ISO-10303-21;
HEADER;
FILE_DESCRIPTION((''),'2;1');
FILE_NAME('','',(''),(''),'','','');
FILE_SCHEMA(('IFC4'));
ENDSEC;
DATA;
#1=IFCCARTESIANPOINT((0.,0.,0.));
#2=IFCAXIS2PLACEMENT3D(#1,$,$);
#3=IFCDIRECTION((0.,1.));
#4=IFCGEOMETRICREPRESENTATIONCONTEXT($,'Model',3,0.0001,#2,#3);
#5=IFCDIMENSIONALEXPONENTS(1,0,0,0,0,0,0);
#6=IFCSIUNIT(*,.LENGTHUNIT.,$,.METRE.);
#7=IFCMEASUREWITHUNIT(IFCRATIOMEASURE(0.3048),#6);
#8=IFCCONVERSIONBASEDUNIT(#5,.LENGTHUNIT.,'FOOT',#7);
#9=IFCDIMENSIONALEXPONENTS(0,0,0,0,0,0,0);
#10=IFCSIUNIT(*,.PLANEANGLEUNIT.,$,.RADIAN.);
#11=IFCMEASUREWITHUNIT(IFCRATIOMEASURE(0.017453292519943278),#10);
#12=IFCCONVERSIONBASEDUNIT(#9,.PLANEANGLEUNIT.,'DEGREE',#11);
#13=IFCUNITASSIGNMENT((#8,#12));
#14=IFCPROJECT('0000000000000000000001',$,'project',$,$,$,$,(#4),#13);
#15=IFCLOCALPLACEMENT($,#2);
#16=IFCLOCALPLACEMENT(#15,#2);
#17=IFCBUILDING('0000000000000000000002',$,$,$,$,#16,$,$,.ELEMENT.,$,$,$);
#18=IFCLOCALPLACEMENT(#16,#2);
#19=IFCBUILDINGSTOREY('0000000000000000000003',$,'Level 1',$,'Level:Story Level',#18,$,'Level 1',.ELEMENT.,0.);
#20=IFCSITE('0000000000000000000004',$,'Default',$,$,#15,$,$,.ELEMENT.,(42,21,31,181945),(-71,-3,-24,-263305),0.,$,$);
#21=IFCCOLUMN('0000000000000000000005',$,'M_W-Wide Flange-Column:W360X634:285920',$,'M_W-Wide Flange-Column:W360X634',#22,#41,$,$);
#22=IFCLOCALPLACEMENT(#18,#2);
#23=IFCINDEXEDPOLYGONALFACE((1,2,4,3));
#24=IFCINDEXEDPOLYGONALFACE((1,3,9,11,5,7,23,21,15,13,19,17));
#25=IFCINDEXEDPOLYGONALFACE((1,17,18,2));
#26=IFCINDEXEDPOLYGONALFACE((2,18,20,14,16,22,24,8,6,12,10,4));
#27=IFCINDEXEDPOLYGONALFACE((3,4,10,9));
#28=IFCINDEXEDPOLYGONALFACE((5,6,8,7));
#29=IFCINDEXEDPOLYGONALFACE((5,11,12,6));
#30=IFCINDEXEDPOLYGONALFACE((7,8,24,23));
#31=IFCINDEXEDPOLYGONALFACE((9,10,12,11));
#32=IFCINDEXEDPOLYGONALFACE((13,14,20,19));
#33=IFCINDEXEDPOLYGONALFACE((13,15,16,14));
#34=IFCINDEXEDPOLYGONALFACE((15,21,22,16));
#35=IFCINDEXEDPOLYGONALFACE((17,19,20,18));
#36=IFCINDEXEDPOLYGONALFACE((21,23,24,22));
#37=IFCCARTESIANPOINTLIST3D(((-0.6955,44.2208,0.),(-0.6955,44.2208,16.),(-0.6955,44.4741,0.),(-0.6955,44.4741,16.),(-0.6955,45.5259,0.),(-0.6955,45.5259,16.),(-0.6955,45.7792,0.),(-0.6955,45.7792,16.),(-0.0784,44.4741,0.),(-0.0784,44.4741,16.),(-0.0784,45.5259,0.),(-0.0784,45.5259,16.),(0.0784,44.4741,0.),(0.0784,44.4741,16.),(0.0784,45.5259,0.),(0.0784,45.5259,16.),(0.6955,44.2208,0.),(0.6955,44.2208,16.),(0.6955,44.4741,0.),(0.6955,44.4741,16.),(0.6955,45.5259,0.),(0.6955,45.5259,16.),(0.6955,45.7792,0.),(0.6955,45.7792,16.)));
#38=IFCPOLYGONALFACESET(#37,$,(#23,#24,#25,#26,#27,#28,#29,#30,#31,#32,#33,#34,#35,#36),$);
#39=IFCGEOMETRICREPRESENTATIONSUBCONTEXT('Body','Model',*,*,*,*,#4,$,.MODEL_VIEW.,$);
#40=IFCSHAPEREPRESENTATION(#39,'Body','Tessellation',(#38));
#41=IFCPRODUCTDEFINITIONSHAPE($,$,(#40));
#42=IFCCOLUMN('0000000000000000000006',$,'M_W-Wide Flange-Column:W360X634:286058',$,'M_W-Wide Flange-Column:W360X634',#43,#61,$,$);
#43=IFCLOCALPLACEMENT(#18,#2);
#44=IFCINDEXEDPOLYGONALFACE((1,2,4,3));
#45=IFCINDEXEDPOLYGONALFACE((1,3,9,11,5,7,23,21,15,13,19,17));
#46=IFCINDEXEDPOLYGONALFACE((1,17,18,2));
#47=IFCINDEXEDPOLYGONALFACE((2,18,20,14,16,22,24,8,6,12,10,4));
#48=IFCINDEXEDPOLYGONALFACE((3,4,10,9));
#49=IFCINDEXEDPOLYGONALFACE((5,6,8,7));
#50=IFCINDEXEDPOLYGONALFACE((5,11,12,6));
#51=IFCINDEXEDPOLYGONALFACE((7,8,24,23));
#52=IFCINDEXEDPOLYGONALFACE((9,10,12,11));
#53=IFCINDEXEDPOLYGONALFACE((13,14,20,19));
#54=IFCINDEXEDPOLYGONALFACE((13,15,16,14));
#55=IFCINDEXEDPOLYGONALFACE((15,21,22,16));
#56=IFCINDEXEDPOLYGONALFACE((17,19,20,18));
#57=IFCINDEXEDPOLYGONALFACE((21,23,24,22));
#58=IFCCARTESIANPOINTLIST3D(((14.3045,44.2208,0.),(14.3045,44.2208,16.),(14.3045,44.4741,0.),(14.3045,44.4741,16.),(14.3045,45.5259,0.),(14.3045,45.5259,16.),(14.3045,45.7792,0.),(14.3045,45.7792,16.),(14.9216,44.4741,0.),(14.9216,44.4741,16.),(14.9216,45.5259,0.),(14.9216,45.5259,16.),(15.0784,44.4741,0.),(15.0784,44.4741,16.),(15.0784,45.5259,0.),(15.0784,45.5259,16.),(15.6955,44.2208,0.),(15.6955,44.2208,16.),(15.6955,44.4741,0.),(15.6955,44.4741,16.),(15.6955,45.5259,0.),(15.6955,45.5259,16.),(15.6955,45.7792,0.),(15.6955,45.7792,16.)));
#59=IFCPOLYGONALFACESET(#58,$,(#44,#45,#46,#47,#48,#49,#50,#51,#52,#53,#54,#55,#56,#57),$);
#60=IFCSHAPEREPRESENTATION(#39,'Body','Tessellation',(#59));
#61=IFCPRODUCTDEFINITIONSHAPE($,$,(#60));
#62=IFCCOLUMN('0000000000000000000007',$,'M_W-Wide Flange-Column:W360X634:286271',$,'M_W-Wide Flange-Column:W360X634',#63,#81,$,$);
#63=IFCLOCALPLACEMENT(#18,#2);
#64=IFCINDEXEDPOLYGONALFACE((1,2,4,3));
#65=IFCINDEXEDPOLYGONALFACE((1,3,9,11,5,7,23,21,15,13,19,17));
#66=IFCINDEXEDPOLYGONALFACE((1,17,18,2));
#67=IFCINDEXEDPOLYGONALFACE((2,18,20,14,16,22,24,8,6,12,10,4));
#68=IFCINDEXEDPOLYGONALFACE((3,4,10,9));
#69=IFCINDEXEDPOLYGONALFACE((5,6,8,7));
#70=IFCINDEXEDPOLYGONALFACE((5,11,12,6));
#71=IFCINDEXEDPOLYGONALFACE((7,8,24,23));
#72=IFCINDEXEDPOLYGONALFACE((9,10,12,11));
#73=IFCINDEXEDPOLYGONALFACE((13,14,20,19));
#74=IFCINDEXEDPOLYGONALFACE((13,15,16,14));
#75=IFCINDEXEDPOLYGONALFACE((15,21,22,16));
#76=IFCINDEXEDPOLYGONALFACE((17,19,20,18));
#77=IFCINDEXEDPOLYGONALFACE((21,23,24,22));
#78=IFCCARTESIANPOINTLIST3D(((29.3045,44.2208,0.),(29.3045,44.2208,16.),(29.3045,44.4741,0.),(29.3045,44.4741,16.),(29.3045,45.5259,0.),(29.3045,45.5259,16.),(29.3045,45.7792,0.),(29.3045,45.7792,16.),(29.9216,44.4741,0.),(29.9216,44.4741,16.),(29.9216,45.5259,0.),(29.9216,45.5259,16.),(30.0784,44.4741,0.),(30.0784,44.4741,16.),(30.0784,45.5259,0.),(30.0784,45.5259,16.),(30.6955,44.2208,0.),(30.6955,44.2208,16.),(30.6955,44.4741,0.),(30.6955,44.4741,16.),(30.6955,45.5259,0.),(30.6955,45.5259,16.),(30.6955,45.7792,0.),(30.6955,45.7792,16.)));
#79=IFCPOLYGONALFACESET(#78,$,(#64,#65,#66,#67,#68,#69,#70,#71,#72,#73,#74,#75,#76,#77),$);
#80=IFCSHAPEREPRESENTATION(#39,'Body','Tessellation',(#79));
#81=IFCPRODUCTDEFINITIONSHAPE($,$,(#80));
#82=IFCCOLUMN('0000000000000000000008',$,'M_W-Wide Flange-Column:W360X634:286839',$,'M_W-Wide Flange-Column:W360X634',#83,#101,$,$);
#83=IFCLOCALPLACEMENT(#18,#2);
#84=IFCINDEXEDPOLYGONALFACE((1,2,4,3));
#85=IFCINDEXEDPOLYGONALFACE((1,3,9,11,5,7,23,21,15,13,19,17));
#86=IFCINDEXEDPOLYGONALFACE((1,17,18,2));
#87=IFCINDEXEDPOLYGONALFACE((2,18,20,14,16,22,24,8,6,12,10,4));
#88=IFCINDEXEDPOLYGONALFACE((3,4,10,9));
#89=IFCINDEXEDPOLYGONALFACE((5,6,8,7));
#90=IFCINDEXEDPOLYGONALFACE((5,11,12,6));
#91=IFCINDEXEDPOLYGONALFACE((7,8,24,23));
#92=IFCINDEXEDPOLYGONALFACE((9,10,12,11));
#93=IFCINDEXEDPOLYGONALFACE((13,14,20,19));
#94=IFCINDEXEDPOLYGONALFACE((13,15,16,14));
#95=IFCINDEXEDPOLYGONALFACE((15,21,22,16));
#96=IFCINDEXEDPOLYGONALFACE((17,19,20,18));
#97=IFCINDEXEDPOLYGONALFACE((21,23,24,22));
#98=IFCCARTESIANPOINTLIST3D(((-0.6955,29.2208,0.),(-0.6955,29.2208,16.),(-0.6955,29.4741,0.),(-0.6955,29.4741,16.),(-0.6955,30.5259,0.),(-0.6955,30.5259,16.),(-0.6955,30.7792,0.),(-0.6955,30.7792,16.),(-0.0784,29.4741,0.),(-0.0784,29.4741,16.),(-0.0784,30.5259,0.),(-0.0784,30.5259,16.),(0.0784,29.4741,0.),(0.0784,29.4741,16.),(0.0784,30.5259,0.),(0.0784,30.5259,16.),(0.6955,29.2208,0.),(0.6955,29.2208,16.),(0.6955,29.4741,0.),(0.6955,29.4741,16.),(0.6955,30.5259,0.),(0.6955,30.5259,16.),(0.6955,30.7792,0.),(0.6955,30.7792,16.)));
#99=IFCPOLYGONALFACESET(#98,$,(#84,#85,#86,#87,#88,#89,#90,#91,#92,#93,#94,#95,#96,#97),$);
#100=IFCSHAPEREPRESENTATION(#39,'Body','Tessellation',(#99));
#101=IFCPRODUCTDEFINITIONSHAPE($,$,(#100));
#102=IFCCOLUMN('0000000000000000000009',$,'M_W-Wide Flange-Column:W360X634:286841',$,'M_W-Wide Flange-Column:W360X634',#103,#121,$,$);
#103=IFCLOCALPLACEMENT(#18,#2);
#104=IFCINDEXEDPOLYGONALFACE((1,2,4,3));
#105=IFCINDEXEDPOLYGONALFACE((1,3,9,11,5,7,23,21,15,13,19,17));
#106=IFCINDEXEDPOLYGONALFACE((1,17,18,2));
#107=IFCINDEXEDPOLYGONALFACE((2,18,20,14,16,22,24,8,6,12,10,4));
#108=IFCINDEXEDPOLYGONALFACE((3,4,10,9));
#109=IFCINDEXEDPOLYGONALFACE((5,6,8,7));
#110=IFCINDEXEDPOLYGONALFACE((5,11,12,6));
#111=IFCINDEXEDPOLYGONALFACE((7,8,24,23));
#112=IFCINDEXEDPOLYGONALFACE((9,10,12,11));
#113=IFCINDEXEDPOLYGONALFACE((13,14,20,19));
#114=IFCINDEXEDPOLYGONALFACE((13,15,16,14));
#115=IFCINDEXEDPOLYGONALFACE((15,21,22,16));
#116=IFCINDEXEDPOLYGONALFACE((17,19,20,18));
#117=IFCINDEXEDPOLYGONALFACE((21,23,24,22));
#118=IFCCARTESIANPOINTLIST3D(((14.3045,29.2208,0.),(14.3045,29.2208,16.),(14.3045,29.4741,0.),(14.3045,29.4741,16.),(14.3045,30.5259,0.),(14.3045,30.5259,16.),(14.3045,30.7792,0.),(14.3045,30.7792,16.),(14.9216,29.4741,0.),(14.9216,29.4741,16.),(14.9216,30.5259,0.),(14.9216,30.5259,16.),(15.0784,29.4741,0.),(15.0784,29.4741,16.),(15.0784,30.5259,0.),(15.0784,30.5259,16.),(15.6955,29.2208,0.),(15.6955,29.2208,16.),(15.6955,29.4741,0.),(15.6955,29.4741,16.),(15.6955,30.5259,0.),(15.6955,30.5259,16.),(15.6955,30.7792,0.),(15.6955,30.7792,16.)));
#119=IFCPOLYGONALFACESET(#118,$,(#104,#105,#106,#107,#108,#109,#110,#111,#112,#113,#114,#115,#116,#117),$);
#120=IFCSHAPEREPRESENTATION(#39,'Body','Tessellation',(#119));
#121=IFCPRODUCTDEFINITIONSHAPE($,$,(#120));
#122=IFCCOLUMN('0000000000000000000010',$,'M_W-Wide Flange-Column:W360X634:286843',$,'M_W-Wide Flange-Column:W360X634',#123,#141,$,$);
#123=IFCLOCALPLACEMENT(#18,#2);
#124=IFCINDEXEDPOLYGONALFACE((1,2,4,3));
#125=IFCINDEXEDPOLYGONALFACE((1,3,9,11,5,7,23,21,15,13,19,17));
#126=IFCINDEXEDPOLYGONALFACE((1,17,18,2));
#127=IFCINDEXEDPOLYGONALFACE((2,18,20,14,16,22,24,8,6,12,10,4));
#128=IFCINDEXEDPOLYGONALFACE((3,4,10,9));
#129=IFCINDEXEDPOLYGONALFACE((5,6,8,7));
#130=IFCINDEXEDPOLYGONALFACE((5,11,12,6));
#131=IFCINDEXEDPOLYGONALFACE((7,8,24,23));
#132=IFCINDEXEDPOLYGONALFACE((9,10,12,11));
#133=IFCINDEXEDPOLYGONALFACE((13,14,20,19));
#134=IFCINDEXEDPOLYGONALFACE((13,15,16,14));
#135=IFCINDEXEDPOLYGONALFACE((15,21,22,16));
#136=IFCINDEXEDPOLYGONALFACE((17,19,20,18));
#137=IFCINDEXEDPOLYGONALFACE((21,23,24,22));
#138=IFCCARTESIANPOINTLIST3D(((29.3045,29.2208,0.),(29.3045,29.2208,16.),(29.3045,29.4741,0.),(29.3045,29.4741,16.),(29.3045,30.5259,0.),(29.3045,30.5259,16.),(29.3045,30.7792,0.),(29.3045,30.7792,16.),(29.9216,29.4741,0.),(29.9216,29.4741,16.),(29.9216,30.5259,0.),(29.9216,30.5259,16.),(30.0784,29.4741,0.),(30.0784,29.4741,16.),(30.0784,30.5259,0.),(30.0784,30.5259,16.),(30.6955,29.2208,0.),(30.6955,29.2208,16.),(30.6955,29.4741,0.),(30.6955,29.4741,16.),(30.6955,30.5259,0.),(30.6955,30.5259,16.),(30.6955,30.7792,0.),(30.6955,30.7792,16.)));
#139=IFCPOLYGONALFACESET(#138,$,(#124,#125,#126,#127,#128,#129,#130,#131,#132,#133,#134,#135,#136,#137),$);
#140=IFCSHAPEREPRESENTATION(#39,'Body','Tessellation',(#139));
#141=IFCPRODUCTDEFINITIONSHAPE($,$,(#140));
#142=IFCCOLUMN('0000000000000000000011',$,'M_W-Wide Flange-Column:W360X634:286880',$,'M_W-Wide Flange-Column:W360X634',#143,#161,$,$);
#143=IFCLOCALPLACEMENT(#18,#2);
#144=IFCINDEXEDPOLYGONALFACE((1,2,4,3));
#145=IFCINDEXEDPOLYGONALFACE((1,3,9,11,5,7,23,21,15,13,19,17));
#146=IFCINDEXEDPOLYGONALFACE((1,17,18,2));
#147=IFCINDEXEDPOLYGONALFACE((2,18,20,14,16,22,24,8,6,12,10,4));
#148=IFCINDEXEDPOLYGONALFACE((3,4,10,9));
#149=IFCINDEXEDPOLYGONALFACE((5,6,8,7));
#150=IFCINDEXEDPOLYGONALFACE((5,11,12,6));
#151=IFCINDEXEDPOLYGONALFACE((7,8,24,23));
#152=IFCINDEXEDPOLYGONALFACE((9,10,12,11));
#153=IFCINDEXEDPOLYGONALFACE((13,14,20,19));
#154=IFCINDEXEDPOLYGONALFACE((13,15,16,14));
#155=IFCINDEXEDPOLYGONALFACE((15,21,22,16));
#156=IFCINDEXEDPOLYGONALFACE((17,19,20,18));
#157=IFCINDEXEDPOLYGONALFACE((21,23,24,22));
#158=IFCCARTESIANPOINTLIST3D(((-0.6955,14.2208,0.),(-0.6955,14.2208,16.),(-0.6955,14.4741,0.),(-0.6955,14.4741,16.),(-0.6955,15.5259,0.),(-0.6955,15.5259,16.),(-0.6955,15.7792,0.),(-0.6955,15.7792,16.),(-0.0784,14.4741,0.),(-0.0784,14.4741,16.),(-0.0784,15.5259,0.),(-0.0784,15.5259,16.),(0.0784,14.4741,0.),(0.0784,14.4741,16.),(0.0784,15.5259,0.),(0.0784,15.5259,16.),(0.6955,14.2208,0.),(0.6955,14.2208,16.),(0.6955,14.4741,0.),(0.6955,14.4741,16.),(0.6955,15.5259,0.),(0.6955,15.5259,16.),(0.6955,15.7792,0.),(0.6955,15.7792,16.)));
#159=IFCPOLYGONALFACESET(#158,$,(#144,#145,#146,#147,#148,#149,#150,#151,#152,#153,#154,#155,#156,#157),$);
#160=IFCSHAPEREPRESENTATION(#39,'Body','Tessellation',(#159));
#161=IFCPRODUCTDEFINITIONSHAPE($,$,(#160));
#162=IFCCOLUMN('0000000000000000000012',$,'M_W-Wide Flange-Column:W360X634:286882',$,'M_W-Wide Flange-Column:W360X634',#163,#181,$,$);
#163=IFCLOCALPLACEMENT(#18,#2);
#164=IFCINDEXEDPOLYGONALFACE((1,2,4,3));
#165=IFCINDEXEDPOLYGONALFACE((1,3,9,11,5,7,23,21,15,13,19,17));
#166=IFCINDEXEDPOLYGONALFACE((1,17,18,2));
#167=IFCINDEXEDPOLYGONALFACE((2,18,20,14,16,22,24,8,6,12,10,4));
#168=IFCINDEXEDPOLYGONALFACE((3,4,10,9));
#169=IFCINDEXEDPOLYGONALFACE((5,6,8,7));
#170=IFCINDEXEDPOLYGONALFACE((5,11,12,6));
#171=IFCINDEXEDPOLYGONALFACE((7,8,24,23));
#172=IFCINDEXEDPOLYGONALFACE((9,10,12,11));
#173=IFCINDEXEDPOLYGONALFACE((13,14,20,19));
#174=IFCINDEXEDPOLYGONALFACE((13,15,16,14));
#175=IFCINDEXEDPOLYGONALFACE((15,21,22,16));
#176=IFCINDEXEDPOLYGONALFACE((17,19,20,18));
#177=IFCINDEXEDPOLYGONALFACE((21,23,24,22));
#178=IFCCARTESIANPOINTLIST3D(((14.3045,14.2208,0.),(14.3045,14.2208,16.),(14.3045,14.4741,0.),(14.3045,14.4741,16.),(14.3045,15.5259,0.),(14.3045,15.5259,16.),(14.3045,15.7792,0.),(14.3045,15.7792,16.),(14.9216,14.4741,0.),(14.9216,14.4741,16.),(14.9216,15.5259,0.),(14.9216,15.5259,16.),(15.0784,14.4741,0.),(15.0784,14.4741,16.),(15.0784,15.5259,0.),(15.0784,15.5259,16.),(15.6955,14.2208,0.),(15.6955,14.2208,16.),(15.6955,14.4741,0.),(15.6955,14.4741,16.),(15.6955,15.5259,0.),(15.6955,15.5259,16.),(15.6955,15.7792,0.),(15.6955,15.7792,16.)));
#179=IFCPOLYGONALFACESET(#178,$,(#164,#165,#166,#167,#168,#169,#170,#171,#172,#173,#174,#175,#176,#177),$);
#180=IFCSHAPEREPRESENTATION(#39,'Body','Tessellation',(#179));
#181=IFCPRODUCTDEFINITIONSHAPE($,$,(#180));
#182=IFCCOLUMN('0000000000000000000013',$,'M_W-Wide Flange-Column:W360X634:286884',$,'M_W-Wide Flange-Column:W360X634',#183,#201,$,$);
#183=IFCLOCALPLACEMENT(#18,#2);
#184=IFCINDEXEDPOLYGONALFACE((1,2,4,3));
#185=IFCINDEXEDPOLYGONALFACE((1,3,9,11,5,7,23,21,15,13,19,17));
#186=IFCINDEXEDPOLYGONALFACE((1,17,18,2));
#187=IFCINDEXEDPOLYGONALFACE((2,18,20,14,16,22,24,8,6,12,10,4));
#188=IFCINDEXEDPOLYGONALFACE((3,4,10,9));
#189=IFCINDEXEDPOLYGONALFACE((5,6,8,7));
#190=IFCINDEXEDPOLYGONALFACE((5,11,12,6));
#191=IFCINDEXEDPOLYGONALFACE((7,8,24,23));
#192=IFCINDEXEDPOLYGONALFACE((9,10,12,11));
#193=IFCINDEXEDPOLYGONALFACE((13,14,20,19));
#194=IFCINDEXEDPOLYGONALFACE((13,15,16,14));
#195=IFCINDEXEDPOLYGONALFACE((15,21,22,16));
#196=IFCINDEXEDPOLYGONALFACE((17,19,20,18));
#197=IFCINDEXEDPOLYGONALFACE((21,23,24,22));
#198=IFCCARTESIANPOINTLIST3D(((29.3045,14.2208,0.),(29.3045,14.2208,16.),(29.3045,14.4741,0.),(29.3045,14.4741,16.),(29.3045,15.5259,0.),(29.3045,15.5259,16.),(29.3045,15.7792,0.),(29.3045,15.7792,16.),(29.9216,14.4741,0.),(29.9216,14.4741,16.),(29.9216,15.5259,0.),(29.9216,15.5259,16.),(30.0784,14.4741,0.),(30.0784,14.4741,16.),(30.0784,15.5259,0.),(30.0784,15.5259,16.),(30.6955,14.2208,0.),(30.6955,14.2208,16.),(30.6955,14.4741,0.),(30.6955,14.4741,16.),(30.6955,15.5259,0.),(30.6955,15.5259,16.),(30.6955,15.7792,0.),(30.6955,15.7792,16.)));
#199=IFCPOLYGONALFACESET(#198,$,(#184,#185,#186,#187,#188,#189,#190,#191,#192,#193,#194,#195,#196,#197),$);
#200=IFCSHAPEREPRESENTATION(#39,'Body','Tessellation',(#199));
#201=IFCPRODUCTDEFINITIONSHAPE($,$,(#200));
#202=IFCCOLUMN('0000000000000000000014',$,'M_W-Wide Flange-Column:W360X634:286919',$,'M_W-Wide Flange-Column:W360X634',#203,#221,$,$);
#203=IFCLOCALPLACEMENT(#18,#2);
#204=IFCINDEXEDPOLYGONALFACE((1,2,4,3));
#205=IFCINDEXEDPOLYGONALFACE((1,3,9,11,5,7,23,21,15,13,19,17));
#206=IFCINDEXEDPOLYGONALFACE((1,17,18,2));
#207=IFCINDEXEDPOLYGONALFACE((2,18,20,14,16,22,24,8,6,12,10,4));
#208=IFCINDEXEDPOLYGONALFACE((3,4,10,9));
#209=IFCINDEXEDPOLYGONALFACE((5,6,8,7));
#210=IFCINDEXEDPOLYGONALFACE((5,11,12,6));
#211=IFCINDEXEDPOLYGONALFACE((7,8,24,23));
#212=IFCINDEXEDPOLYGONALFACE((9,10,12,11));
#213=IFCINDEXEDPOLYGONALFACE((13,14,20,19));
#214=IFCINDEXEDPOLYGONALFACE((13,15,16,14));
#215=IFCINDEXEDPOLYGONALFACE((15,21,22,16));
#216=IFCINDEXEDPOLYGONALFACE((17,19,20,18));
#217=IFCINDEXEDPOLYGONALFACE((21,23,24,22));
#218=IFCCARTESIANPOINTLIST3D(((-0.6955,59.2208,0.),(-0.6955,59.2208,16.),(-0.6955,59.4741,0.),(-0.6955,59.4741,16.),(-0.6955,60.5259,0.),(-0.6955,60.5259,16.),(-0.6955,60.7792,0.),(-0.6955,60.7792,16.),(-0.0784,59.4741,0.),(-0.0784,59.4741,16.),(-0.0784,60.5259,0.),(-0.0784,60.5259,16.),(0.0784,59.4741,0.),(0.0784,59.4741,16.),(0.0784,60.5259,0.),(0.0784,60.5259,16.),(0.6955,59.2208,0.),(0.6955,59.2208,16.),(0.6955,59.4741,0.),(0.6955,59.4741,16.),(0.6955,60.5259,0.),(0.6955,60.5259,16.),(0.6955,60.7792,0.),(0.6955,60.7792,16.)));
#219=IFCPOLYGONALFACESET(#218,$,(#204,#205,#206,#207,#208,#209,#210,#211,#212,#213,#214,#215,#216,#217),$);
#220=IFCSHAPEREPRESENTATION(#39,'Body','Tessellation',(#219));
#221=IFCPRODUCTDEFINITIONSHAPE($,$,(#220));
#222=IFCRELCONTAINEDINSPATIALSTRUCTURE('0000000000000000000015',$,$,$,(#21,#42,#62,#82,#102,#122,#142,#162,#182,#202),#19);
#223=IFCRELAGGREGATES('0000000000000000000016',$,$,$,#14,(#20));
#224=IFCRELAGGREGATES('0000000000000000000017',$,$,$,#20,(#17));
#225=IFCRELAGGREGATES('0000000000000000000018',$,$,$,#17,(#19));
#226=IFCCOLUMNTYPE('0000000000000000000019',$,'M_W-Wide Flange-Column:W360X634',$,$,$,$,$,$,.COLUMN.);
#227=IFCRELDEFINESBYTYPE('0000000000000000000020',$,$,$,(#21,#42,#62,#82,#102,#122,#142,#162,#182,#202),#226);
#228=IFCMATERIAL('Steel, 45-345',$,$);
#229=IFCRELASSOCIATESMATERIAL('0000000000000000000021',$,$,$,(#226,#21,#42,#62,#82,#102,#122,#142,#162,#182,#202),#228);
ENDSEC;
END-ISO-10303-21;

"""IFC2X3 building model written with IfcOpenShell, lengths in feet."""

from ifc_helpers import new_model, entity, si_unit, converted_unit, direction, frame, origin, place, context, subcontext, project, spatial, polyline, outline, extrude, source, transform, mapped, material, type_object, type_shapes, element, save


model = new_model("IFC2X3")

# Units and contexts
model_context = context("Model", 3, precision=0.0001, world=origin(), true_north=direction((0.0, 1.0)))
body_context = subcontext(model_context, "Body", "Model", "MODEL_VIEW")
ifc_project = project(units=[converted_unit("LENGTHUNIT", "FOOT", entity("IfcRatioMeasure", 0.3048), si_unit("LENGTHUNIT", "METRE"), dimensions=[1, 0, 0, 0, 0, 0, 0]), converted_unit("PLANEANGLEUNIT", "DEGREE", entity("IfcRatioMeasure", 0.017453292519943278), si_unit("PLANEANGLEUNIT", "RADIAN"), dimensions=[0, 0, 0, 0, 0, 0, 0])], contexts=[model_context])

# Site, building, storey
site_placement = place(None, origin())
site = spatial("IfcSite", under=ifc_project, at=site_placement, Name="Default", CompositionType="ELEMENT", RefLatitude=(42, 21, 31, 181945), RefLongitude=(-71, -3, -24, -263305), RefElevation=0.0)
building_placement = place(site_placement, origin())
building = spatial("IfcBuilding", under=site, at=building_placement, CompositionType="ELEMENT")
storey_placement = place(building_placement, origin())
storey = spatial("IfcBuildingStorey", under=building, at=storey_placement, Name="Level 1", ObjectType="Level:Story Level", LongName="Level 1", CompositionType="ELEMENT", Elevation=0.0)

# Columns
ifc_material = material(Name="Steel, 45-345")
column_type = type_object("IfcColumnType", Name="M_W-Wide Flange-Column:W360X634", PredefinedType="COLUMN", material=ifc_material)
shared_shape = source(origin(), body_context, "Body", "SweptSolid", [
    extrude(outline(polyline([(0.5259, -0.6955), (0.7792, -0.6955), (0.7792, 0.6955), (0.5259, 0.6955), (0.5259, 0.0784), (-0.5259, 0.0784), (-0.5259, 0.6955), (-0.7792, 0.6955), (-0.7792, -0.6955), (-0.5259, -0.6955), (-0.5259, -0.0784), (0.5259, -0.0784), (0.5259, -0.6955)])), frame((0.0, 0.0, 0.0), z_axis=(0.0, 0.0, 1.0), x_axis=(0.0, -1.0, 0.0)), (0.0, 0.0, 1.0), 16.0),
])
type_shapes(column_type, [shared_shape])
for number, where, name in (
    (1, (0.0, 45.0, 0.0), "M_W-Wide Flange-Column:W360X634:285920"),
    (2, (15.0, 45.0, 0.0), "M_W-Wide Flange-Column:W360X634:286058"),
    (3, (30.0, 45.0, 0.0), "M_W-Wide Flange-Column:W360X634:286271"),
    (4, (0.0, 30.0, 0.0), "M_W-Wide Flange-Column:W360X634:286839"),
    (5, (15.0, 30.0, 0.0), "M_W-Wide Flange-Column:W360X634:286841"),
    (6, (30.0, 30.0, 0.0), "M_W-Wide Flange-Column:W360X634:286843"),
    (7, (0.0, 15.0, 0.0), "M_W-Wide Flange-Column:W360X634:286880"),
    (8, (15.0, 15.0, 0.0), "M_W-Wide Flange-Column:W360X634:286882"),
    (9, (30.0, 15.0, 0.0), "M_W-Wide Flange-Column:W360X634:286884"),
    (10, (0.0, 60.0, 0.0), "M_W-Wide Flange-Column:W360X634:286919"),
):
    element("IfcColumn", number, at=place(storey_placement, frame(where)), inside=storey, type_object=column_type, material=ifc_material, Name=name, ObjectType="M_W-Wide Flange-Column:W360X634", context=body_context, shape_type="MappedRepresentation", body=[
        mapped(shared_shape, transform((0.0, 0.0, 0.0), scale=1.0)),
    ])

save(model, "model.ifc")
